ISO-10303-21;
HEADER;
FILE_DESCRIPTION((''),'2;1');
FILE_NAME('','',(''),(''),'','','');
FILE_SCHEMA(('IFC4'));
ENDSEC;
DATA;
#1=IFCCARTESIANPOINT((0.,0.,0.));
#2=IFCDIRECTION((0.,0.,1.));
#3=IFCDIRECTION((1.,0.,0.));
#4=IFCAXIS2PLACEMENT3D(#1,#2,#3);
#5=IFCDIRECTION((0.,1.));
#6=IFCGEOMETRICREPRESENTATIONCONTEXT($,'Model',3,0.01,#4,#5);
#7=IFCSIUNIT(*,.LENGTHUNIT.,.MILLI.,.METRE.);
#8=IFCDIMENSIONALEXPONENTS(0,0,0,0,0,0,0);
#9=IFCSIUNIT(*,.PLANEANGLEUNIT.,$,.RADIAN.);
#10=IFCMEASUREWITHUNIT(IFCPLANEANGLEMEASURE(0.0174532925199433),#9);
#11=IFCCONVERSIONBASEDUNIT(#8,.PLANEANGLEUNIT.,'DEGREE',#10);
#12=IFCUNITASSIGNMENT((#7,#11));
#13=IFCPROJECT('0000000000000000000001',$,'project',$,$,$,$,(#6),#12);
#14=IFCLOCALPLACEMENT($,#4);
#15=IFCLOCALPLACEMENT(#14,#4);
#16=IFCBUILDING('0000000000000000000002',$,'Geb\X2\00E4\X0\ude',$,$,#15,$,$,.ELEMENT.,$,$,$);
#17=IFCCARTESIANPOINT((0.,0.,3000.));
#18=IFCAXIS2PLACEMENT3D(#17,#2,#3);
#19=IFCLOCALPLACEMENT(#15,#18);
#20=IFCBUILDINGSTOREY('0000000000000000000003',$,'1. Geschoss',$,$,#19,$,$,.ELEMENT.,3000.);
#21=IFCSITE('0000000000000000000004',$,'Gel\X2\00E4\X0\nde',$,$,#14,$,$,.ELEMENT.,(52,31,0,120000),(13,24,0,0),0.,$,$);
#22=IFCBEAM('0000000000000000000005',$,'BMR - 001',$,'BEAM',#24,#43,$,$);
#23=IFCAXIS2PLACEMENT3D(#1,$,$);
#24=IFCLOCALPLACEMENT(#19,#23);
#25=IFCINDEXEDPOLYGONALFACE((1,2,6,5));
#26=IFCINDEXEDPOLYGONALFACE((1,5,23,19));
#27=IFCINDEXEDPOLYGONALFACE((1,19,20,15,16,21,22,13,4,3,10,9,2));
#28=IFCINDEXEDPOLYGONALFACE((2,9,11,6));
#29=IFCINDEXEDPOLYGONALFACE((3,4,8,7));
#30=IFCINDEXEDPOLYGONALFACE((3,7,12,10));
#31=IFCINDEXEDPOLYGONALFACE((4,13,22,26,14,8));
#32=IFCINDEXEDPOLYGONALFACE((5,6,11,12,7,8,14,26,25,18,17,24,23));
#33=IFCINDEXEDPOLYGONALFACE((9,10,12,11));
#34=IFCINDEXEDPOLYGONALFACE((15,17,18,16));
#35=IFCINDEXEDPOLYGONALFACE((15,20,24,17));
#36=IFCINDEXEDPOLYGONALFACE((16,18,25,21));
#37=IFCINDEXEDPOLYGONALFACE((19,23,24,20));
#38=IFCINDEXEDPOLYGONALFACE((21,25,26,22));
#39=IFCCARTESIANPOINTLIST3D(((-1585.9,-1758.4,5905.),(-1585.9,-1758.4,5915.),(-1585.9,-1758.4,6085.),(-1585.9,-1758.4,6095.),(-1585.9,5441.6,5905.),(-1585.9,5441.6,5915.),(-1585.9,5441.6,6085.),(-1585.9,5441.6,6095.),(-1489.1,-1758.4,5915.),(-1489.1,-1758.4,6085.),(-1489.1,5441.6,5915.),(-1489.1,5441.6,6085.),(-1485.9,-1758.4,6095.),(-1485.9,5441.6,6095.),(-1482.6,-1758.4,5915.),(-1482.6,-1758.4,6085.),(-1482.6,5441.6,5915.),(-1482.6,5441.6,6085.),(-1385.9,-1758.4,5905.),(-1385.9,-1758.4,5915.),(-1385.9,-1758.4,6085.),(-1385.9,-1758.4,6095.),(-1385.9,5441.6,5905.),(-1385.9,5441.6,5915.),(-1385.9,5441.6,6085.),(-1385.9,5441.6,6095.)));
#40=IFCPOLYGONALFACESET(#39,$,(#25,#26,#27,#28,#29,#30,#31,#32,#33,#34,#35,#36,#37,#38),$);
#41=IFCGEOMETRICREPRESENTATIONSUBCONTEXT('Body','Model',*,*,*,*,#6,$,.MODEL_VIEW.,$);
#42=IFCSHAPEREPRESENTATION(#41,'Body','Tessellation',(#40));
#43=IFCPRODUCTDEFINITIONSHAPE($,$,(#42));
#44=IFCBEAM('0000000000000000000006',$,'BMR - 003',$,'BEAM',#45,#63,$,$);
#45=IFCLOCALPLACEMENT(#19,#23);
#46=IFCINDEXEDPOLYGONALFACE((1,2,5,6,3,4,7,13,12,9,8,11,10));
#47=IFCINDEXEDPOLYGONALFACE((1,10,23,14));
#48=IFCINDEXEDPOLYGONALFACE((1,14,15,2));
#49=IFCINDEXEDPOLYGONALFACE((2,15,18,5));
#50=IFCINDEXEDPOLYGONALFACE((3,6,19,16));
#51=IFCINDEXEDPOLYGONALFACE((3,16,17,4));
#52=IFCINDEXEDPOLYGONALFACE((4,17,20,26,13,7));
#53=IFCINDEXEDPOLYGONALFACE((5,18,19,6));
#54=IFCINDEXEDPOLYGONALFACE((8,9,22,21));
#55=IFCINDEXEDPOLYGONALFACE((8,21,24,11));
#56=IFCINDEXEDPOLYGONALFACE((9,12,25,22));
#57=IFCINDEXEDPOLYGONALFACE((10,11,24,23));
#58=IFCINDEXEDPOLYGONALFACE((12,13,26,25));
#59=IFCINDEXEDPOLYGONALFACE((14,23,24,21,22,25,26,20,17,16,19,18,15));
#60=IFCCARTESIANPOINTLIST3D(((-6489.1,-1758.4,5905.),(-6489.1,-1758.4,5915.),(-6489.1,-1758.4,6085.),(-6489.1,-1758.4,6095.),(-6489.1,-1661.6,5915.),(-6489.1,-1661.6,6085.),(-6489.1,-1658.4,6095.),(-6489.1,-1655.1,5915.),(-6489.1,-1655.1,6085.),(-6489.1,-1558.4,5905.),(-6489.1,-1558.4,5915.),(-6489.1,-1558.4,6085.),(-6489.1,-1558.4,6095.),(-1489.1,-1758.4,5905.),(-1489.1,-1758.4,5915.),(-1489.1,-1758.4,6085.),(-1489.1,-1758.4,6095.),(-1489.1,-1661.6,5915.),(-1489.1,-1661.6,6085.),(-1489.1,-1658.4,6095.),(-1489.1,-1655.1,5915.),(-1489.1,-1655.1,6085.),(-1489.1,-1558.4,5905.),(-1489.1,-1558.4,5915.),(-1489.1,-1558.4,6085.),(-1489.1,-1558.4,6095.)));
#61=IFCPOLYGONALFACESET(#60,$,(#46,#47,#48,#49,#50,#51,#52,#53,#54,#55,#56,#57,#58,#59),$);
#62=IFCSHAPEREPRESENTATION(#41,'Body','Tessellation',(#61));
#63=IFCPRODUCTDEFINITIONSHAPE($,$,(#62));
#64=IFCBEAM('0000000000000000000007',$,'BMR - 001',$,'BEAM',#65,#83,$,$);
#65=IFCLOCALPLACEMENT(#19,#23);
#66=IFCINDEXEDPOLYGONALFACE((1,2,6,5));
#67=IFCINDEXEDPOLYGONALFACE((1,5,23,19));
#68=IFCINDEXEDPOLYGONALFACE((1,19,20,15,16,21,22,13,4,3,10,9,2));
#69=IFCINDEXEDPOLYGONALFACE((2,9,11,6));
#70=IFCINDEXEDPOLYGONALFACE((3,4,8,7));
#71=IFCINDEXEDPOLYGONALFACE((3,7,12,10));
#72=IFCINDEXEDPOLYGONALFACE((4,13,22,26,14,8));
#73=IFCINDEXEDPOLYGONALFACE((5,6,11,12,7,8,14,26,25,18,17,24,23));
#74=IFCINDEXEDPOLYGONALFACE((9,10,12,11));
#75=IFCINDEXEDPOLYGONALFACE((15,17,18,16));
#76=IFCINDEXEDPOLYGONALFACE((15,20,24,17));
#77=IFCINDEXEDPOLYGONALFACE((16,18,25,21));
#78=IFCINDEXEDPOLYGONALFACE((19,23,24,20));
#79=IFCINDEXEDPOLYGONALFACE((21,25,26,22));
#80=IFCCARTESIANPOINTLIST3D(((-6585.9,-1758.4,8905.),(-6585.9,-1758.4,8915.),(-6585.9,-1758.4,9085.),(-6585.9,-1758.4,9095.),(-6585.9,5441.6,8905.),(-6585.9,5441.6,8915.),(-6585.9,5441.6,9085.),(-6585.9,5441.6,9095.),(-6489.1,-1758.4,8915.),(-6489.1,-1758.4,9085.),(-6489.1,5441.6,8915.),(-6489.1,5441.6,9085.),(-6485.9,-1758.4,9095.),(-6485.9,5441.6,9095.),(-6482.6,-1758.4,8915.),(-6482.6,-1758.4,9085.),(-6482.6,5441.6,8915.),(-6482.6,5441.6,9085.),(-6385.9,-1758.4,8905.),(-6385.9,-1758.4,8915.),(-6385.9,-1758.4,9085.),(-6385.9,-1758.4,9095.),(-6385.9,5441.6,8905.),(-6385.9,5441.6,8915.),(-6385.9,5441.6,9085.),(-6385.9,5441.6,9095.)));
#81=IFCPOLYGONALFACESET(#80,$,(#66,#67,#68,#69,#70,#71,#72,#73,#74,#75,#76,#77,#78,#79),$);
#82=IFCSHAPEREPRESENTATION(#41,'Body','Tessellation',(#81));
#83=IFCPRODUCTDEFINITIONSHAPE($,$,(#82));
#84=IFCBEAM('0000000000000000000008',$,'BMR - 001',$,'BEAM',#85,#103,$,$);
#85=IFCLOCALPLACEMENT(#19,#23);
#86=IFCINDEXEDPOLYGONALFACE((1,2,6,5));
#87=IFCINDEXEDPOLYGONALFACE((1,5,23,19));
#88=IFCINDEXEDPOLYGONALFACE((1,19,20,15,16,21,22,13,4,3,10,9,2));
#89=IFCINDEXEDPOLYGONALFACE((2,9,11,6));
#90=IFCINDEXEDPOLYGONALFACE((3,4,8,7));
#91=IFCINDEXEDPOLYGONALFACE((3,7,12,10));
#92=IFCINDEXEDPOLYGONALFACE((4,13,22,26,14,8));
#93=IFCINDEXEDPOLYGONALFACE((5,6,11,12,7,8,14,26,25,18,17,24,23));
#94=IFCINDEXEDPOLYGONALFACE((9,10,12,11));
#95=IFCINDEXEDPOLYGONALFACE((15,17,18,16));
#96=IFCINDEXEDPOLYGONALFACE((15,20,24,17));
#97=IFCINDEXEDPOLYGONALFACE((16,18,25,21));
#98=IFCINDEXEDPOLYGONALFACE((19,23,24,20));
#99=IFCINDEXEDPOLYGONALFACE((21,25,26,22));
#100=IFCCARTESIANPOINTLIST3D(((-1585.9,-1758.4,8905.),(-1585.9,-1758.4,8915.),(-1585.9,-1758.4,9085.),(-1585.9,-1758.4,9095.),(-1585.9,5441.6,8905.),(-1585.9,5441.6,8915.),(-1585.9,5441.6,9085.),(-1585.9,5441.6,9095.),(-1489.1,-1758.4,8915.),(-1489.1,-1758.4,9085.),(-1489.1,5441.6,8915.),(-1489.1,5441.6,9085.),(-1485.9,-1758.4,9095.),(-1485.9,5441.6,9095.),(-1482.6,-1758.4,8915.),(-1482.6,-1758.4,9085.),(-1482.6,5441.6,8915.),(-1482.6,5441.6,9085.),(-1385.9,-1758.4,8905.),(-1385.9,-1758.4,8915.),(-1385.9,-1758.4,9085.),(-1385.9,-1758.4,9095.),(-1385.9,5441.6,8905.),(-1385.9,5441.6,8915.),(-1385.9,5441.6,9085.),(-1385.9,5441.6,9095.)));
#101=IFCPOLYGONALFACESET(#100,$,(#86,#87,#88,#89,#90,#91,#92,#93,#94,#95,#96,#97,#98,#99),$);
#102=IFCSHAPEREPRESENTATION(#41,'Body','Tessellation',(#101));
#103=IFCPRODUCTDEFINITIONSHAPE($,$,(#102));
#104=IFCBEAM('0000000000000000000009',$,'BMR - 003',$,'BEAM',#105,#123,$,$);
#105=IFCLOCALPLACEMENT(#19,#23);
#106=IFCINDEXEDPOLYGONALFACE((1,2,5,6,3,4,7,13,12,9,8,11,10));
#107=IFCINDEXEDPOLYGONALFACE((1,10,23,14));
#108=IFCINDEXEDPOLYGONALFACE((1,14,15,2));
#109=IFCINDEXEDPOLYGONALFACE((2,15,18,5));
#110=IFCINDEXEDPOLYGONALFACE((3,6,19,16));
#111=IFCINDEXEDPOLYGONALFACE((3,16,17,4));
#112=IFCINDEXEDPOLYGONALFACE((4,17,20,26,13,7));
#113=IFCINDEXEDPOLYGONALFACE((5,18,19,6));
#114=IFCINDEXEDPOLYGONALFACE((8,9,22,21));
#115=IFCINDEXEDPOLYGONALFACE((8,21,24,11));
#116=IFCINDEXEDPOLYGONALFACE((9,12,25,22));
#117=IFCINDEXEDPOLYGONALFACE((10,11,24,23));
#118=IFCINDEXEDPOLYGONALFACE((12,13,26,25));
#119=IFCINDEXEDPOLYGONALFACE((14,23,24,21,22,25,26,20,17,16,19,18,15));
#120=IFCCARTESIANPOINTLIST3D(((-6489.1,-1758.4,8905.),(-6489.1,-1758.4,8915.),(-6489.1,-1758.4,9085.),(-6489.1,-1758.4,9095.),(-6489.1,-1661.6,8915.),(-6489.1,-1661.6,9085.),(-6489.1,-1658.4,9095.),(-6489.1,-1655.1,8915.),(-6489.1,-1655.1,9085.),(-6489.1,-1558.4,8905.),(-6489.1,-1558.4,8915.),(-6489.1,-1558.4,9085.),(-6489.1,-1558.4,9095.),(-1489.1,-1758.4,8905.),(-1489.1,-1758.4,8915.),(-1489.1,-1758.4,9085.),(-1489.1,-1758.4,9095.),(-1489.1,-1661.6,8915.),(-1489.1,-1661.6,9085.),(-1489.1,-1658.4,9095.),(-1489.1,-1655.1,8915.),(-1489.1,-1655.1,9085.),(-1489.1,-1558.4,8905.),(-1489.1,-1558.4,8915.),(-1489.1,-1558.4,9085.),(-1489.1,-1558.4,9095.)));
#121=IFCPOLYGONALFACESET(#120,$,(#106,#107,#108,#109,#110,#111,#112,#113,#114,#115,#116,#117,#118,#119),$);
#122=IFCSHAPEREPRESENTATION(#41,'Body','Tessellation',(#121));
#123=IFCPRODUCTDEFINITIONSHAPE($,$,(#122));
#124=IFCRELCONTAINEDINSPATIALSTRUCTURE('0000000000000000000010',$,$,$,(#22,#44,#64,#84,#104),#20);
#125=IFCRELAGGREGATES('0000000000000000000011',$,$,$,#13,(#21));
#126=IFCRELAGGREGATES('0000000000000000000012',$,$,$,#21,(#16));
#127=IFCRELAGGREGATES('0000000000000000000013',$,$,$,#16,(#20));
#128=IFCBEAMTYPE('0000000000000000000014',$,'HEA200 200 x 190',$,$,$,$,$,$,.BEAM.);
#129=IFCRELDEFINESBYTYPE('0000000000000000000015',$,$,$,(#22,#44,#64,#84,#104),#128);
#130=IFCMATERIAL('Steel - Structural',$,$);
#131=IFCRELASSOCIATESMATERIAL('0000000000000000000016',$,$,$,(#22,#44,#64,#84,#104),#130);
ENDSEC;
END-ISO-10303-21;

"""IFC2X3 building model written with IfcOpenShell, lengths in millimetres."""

from ifc_helpers import new_model, entity, si_unit, converted_unit, direction, frame, origin_with_axes, place, context, subcontext, project, spatial, polyline, outline, extrude, material, type_object, element, save


model = new_model("IFC2X3")

# Units and contexts
model_context = context("Model", 3, precision=0.01, world=origin_with_axes(), true_north=direction((0.0, 1.0)))
body_context = subcontext(model_context, "Body", "Model", "MODEL_VIEW")
ifc_project = project(units=[si_unit("LENGTHUNIT", "METRE", prefix="MILLI"), converted_unit("PLANEANGLEUNIT", "DEGREE", entity("IfcPlaneAngleMeasure", 0.0174532925199433), si_unit("PLANEANGLEUNIT", "RADIAN"), dimensions=[0, 0, 0, 0, 0, 0, 0])], contexts=[model_context])

# Site, building, storey
site_placement = place(None, origin_with_axes())
site = spatial("IfcSite", under=ifc_project, at=site_placement, Name="Gelände", CompositionType="ELEMENT", RefLatitude=(52, 31, 0, 120000), RefLongitude=(13, 24, 0, 0), RefElevation=0.0)
building_placement = place(site_placement, origin_with_axes())
building = spatial("IfcBuilding", under=site, at=building_placement, Name="Gebäude", CompositionType="ELEMENT")
storey_placement = place(building_placement, frame((0.0, 0.0, 3000.0), z_axis=(0.0, 0.0, 1.0), x_axis=(1.0, 0.0, 0.0)))
storey = spatial("IfcBuildingStorey", under=building, at=storey_placement, Name="1. Geschoss", CompositionType="ELEMENT", Elevation=3000.0)

# Beams
ifc_material = material(Name="Steel - Structural")
beam_type = type_object("IfcBeamType", Name="HEA200 200 x 190", PredefinedType="BEAM")
for number, where, z_axis, x_axis, name in (
    (1, (-1485.9, -1758.4, 6000.0), (0.0, 0.0, 1.0), (1.0, 0.0, 0.0), "BMR - 001"),
):
    element("IfcBeam", number, at=place(storey_placement, frame(where, z_axis=z_axis, x_axis=x_axis)), inside=storey, type_object=beam_type, material=ifc_material, Name=name, ObjectType="BEAM", context=body_context, shape_type="SweptSolid", body=[
        extrude(outline(polyline([(0.0, 95.0), (-100.0, 95.0), (-100.0, 85.0), (-3.2, 85.0), (-3.2, -85.0), (-100.0, -85.0), (-100.0, -95.0), (100.0, -95.0), (100.0, -85.0), (3.2, -85.0), (3.2, 85.0), (100.0, 85.0), (100.0, 95.0), (0.0, 95.0)])), frame((0.0, 7200.0, 0.0), z_axis=(0.0, -1.0, 0.0), x_axis=(1.0, 0.0, 0.0)), (0.0, 0.0, 1.0), 7200.0),
    ])
beam_1_placement = place(storey_placement, frame((-6489.1, -1658.4, 6000.0), z_axis=(0.0, 0.0, 1.0), x_axis=(0.0, -1.0, 0.0)))
element("IfcBeam", 2, at=beam_1_placement, inside=storey, type_object=beam_type, material=ifc_material, Name="BMR - 003", ObjectType="BEAM", context=body_context, shape_type="SweptSolid", body=[
    extrude(outline(polyline([(0.0, 95.0), (-100.0, 95.0), (-100.0, 85.0), (-3.2, 85.0), (-3.2, -85.0), (-100.0, -85.0), (-100.0, -95.0), (100.0, -95.0), (100.0, -85.0), (3.2, -85.0), (3.2, 85.0), (100.0, 85.0), (100.0, 95.0), (0.0, 95.0)])), frame((0.0, 5000.0, 0.0), z_axis=(0.0, -1.0, 0.0), x_axis=(1.0, 0.0, 0.0)), (0.0, 0.0, 1.0), 5000.0),
])
for number, where, z_axis, x_axis, name in (
    (3, (-6485.9, -1758.4, 9000.0), (0.0, 0.0, 1.0), (1.0, 0.0, 0.0), "BMR - 001"),
    (4, (-1485.9, -1758.4, 9000.0), (0.0, 0.0, 1.0), (1.0, 0.0, 0.0), "BMR - 001"),
):
    element("IfcBeam", number, at=place(storey_placement, frame(where, z_axis=z_axis, x_axis=x_axis)), inside=storey, type_object=beam_type, material=ifc_material, Name=name, ObjectType="BEAM", context=body_context, shape_type="SweptSolid", body=[
        extrude(outline(polyline([(0.0, 95.0), (-100.0, 95.0), (-100.0, 85.0), (-3.2, 85.0), (-3.2, -85.0), (-100.0, -85.0), (-100.0, -95.0), (100.0, -95.0), (100.0, -85.0), (3.2, -85.0), (3.2, 85.0), (100.0, 85.0), (100.0, 95.0), (0.0, 95.0)])), frame((0.0, 7200.0, 0.0), z_axis=(0.0, -1.0, 0.0), x_axis=(1.0, 0.0, 0.0)), (0.0, 0.0, 1.0), 7200.0),
    ])
beam_2_placement = place(storey_placement, frame((-6489.1, -1658.4, 9000.0), z_axis=(0.0, 0.0, 1.0), x_axis=(0.0, -1.0, 0.0)))
element("IfcBeam", 5, at=beam_2_placement, inside=storey, type_object=beam_type, material=ifc_material, Name="BMR - 003", ObjectType="BEAM", context=body_context, shape_type="SweptSolid", body=[
    extrude(outline(polyline([(0.0, 95.0), (-100.0, 95.0), (-100.0, 85.0), (-3.2, 85.0), (-3.2, -85.0), (-100.0, -85.0), (-100.0, -95.0), (100.0, -95.0), (100.0, -85.0), (3.2, -85.0), (3.2, 85.0), (100.0, 85.0), (100.0, 95.0), (0.0, 95.0)])), frame((0.0, 5000.0, 0.0), z_axis=(0.0, -1.0, 0.0), x_axis=(1.0, 0.0, 0.0)), (0.0, 0.0, 1.0), 5000.0),
])

save(model, "model.ifc")
